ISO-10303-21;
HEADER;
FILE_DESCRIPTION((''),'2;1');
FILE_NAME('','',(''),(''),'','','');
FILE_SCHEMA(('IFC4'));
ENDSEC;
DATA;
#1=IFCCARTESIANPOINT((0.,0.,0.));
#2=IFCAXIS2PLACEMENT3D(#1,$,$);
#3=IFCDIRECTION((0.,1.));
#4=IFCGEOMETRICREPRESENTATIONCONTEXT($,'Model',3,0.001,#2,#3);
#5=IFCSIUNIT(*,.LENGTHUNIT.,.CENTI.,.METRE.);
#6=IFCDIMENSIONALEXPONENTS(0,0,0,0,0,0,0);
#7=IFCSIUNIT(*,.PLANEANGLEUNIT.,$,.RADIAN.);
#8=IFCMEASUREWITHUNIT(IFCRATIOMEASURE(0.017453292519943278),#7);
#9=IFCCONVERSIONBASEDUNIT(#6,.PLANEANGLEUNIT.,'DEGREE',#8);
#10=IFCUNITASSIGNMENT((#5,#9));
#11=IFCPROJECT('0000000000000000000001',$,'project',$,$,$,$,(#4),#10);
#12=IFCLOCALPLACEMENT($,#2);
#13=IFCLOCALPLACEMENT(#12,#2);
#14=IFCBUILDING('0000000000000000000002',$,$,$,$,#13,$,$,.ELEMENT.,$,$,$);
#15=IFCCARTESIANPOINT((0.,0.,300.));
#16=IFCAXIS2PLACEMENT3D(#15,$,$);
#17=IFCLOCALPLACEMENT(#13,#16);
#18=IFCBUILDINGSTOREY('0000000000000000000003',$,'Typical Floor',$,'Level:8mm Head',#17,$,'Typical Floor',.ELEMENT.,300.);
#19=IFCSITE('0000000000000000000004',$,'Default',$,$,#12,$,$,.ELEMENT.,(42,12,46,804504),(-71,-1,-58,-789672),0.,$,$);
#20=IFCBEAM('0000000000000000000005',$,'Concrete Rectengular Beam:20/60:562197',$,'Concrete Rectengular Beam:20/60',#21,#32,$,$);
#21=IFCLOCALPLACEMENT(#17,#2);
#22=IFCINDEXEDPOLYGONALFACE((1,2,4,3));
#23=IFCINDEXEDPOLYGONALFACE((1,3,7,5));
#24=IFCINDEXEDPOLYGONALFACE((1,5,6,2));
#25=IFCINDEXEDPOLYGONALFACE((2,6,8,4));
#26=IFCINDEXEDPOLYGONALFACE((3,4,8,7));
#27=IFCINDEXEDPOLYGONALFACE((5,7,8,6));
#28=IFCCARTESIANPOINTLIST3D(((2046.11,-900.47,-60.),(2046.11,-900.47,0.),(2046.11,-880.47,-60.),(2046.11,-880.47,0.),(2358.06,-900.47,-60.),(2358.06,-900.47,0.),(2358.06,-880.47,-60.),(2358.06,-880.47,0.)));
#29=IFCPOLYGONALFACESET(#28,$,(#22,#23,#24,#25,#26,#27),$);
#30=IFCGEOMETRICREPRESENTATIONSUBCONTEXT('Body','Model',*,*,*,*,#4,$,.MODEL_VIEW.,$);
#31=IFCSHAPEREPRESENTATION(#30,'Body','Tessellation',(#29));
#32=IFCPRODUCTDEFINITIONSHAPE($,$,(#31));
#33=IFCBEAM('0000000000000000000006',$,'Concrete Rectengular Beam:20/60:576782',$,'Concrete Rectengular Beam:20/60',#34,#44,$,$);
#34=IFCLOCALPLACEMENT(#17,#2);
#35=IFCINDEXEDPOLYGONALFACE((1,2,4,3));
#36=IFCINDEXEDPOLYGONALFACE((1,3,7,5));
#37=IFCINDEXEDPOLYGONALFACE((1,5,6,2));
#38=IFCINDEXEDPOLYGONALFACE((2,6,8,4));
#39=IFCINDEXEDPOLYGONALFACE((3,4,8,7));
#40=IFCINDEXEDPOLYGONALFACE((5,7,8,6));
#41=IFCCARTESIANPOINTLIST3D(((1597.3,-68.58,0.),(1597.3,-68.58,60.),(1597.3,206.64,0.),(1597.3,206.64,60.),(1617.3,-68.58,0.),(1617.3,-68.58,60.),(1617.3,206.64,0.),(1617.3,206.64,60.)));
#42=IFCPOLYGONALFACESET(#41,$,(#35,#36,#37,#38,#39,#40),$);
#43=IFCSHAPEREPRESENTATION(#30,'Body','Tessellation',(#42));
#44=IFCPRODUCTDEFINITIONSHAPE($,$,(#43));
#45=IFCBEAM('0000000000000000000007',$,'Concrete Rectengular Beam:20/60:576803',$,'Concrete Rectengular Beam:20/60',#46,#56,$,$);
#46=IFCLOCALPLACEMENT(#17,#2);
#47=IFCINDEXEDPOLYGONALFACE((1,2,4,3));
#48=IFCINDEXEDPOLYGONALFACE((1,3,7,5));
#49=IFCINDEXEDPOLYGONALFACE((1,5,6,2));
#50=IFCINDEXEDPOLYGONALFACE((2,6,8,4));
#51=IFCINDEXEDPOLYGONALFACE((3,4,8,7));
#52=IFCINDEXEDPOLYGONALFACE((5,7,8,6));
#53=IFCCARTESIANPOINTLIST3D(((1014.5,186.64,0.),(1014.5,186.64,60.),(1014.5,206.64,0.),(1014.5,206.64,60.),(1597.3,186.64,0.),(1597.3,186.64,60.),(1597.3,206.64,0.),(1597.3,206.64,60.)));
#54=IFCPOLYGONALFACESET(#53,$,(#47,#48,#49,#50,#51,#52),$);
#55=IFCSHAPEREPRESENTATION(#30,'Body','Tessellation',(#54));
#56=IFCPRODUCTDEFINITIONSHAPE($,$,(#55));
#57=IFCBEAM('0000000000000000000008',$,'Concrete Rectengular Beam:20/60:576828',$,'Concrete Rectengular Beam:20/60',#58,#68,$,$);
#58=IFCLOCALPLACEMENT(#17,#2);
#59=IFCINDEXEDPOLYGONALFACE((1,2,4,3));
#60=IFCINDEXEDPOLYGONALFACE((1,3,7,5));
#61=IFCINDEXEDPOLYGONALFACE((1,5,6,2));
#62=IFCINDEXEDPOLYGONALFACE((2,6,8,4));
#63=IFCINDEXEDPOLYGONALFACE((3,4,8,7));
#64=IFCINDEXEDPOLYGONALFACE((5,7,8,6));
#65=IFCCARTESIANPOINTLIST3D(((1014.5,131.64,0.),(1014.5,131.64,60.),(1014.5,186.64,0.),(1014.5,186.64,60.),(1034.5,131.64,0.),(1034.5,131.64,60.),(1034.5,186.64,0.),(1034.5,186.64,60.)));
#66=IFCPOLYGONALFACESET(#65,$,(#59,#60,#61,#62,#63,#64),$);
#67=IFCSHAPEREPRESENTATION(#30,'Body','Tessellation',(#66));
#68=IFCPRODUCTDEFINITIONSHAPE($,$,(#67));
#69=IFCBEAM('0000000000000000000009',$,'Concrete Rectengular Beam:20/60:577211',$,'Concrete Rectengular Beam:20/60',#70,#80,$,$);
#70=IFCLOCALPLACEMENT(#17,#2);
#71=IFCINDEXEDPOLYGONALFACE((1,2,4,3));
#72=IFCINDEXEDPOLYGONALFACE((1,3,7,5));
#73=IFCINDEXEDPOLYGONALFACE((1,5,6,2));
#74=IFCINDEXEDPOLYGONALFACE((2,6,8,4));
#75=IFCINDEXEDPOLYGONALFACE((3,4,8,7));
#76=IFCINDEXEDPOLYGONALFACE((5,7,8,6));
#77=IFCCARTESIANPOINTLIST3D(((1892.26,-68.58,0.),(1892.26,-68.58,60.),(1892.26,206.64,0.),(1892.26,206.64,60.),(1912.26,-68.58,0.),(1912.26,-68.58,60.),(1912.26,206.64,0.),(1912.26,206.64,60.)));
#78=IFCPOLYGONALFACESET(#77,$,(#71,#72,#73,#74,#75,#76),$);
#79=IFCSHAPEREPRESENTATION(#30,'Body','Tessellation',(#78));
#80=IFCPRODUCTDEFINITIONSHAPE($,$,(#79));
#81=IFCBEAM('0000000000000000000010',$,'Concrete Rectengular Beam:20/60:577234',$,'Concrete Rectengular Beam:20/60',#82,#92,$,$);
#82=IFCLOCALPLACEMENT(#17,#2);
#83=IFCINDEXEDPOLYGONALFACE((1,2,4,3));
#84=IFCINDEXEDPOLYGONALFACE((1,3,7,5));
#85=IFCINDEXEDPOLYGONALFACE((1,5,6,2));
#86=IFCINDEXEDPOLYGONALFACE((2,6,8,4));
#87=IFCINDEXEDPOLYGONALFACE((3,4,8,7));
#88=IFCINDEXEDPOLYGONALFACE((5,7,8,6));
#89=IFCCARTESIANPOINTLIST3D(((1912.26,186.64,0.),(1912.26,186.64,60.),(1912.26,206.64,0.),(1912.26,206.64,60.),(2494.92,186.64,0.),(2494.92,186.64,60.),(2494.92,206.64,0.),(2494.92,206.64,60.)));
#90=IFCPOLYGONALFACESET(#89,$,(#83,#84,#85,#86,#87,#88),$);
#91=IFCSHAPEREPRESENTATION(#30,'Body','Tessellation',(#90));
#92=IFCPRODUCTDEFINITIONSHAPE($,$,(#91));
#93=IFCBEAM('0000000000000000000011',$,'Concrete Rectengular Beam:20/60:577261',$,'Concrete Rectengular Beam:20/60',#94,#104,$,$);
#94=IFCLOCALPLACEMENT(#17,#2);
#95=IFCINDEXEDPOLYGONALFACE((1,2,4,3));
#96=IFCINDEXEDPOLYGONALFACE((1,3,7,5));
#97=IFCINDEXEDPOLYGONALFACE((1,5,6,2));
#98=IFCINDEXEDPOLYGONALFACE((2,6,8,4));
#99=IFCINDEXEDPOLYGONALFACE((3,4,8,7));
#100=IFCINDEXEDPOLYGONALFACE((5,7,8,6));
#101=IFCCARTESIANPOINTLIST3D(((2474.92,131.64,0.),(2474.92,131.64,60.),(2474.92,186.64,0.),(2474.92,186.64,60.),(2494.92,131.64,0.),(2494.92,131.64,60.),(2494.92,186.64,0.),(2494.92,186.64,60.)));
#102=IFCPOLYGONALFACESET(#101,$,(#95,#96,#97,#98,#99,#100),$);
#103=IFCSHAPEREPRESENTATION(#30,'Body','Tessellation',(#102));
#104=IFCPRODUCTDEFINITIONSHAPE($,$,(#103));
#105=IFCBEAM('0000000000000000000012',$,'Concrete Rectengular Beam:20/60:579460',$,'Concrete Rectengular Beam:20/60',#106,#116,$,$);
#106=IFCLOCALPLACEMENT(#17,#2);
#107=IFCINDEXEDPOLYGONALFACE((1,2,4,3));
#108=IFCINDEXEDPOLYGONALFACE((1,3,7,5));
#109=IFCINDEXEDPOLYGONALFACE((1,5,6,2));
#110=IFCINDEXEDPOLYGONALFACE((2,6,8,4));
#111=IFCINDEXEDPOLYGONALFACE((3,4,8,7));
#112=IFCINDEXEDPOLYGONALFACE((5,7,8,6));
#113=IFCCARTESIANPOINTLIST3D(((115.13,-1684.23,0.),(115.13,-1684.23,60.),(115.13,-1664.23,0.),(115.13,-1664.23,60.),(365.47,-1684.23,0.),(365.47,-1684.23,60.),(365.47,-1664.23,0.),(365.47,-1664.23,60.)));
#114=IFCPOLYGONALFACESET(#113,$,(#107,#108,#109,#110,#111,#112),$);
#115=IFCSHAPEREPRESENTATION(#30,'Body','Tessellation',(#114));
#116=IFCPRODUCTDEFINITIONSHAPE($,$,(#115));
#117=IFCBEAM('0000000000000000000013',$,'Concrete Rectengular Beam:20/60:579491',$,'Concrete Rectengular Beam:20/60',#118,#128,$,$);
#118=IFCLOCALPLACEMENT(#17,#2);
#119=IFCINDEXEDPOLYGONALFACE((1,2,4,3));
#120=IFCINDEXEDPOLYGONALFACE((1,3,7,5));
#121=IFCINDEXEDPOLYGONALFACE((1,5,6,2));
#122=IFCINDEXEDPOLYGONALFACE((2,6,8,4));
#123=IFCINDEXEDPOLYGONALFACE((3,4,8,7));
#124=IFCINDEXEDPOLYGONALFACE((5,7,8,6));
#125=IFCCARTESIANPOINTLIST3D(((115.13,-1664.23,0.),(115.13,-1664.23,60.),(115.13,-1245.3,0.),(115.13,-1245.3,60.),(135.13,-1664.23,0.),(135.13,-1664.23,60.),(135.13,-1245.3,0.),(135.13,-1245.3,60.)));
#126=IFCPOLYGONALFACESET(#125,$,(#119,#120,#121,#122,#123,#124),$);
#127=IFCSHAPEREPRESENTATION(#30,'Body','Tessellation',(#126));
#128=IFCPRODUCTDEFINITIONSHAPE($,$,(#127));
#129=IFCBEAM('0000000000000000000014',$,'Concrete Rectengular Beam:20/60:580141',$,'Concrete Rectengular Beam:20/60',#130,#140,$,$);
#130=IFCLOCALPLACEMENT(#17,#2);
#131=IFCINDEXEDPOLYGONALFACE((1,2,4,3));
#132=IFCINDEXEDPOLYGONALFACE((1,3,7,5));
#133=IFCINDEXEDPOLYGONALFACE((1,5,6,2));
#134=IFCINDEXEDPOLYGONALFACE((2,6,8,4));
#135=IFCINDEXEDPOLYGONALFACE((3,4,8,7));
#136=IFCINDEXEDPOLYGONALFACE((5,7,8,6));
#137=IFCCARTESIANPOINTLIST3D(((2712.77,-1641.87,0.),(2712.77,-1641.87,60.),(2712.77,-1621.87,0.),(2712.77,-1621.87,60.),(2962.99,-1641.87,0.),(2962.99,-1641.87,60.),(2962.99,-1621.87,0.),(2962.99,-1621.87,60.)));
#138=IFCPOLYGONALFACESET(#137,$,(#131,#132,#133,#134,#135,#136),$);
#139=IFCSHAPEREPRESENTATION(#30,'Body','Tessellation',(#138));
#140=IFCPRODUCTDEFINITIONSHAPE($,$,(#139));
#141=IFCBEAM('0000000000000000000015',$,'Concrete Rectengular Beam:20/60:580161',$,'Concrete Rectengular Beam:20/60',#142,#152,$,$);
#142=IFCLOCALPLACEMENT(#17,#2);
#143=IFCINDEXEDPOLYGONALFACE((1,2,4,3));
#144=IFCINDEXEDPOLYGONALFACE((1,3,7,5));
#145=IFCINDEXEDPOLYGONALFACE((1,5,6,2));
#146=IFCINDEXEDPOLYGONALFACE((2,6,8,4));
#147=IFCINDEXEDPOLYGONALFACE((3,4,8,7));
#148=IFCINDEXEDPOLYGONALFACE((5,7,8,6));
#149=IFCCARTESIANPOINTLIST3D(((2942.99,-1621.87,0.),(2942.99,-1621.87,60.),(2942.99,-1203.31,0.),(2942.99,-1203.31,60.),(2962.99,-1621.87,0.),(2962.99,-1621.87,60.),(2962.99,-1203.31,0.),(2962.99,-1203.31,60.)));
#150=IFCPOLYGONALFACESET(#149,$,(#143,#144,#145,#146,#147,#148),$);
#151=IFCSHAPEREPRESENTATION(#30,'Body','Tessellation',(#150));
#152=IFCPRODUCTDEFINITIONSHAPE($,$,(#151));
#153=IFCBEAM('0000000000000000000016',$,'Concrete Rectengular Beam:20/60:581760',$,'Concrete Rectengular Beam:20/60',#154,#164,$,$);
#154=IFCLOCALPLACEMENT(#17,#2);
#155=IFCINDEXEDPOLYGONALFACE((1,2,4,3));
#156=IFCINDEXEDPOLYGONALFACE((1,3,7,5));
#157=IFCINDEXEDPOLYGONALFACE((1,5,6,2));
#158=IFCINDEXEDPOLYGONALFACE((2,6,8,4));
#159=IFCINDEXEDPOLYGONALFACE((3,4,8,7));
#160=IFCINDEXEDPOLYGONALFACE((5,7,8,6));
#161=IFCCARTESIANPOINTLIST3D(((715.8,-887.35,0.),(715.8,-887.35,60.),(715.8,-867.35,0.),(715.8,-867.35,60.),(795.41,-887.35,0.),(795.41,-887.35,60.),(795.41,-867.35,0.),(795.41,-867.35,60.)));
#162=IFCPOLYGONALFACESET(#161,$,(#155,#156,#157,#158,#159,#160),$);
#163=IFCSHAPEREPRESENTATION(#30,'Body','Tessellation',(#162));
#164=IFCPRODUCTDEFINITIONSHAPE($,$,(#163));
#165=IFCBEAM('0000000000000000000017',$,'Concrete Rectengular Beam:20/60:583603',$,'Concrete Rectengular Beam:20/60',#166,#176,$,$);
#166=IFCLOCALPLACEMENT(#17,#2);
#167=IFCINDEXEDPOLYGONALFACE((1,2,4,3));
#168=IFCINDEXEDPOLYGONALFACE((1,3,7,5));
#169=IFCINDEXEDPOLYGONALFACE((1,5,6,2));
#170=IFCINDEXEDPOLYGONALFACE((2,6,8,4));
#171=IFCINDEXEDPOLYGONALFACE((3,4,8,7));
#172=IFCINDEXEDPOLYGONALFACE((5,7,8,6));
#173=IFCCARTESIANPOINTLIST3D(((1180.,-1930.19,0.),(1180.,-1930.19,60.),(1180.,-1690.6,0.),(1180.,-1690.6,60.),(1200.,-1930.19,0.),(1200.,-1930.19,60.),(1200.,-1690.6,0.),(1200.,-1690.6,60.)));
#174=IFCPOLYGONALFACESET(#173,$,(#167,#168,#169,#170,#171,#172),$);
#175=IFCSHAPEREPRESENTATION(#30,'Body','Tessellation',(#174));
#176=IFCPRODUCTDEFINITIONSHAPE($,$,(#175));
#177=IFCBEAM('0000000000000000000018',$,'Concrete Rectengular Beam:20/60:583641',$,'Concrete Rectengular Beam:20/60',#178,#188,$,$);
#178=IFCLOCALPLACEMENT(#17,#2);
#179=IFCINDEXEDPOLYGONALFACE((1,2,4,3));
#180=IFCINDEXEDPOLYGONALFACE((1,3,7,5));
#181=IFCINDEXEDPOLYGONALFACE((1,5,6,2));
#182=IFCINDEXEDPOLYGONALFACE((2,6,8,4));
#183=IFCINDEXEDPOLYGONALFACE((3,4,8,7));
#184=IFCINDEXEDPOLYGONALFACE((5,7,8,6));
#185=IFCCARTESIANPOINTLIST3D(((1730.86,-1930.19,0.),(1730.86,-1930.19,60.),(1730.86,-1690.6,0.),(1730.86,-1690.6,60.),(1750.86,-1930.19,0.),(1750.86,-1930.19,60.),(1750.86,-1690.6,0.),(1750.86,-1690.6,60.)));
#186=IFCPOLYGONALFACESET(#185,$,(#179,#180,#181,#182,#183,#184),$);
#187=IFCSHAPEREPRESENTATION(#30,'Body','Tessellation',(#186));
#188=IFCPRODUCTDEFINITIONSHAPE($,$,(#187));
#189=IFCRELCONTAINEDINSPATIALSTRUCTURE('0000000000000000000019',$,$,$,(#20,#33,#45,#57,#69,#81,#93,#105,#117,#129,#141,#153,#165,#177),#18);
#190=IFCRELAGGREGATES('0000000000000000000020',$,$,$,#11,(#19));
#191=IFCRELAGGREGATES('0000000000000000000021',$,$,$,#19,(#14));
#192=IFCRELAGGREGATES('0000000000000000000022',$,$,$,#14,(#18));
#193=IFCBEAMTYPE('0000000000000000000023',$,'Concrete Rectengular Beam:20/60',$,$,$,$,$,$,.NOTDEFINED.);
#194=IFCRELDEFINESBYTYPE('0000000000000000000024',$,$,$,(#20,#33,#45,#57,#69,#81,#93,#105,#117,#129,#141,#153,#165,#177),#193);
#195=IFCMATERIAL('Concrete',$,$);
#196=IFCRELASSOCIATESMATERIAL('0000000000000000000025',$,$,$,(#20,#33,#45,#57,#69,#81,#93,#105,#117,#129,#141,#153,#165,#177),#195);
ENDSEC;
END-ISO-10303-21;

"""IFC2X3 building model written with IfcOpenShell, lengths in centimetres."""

from ifc_helpers import new_model, entity, si_unit, converted_unit, direction, frame, frame_2d, origin, origin_2d_with_axis, place, context, subcontext, project, spatial, rectangle, extrude, material, type_object, element, save


model = new_model("IFC2X3")

# Units and contexts
model_context = context("Model", 3, precision=0.001, world=origin(), true_north=direction((0.0, 1.0)))
body_context = subcontext(model_context, "Body", "Model", "MODEL_VIEW")
ifc_project = project(units=[si_unit("LENGTHUNIT", "METRE", prefix="CENTI"), converted_unit("PLANEANGLEUNIT", "DEGREE", entity("IfcRatioMeasure", 0.017453292519943278), si_unit("PLANEANGLEUNIT", "RADIAN"), dimensions=[0, 0, 0, 0, 0, 0, 0])], contexts=[model_context])

# Site, building, storey
site_placement = place(None, origin())
site = spatial("IfcSite", under=ifc_project, at=site_placement, Name="Default", CompositionType="ELEMENT", RefLatitude=(42, 12, 46, 804504), RefLongitude=(-71, -1, -58, -789672), RefElevation=0.0)
building_placement = place(site_placement, origin())
building = spatial("IfcBuilding", under=site, at=building_placement, CompositionType="ELEMENT")
storey_placement = place(building_placement, frame((0.0, 0.0, 300.0)))
storey = spatial("IfcBuildingStorey", under=building, at=storey_placement, Name="Typical Floor", ObjectType="Level:8mm Head", LongName="Typical Floor", CompositionType="ELEMENT", Elevation=300.0)

# Beams
ifc_material = material(Name="Concrete")
beam_type_1 = type_object("IfcBeamType", Name="Concrete Rectengular Beam:20/60", PredefinedType="NOTDEFINED")
beam_1_placement = place(storey_placement, frame((2368.06, -890.47, 0.0), z_axis=(0.0, 0.0, 1.0), x_axis=(-1.0, 0.0, 0.0)))
element("IfcBeam", 1, at=beam_1_placement, inside=storey, type_object=beam_type_1, material=ifc_material, Name="Concrete Rectengular Beam:20/60:562197", ObjectType="Concrete Rectengular Beam:20/60", context=body_context, shape_type="SweptSolid", body=[
    extrude(rectangle(XDim=60.0, YDim=20.0, at=frame_2d((0.0, 0.0), x_axis=(1.0, 0.0))), frame((10.0, 0.0, -30.0), z_axis=(1.0, 0.0, 0.0), x_axis=(0.0, 0.0, -1.0)), (0.0, 0.0, 1.0), 311.95),
])
beam_2_placement = place(storey_placement, frame((1607.3, -68.58, 0.0), z_axis=(0.0, 0.0, 1.0), x_axis=(0.0, 1.0, 0.0)))
element("IfcBeam", 2, at=beam_2_placement, inside=storey, type_object=beam_type_1, material=ifc_material, Name="Concrete Rectengular Beam:20/60:576782", ObjectType="Concrete Rectengular Beam:20/60", context=body_context, shape_type="SweptSolid", body=[
    extrude(rectangle(XDim=60.0, YDim=20.0, at=frame_2d((0.0, 0.0), x_axis=(1.0, 0.0))), frame((0.0, 0.0, 30.0), z_axis=(1.0, 0.0, 0.0), x_axis=(0.0, 0.0, -1.0)), (0.0, 0.0, 1.0), 275.22),
])
beam_3_placement = place(storey_placement, frame((1607.3, 196.64, 0.0), z_axis=(0.0, 0.0, 1.0), x_axis=(-1.0, 0.0, 0.0)))
element("IfcBeam", 3, at=beam_3_placement, inside=storey, type_object=beam_type_1, material=ifc_material, Name="Concrete Rectengular Beam:20/60:576803", ObjectType="Concrete Rectengular Beam:20/60", context=body_context, shape_type="SweptSolid", body=[
    extrude(rectangle(XDim=60.0, YDim=20.0, at=frame_2d((0.0, 0.0), x_axis=(1.0, 0.0))), frame((10.0, 0.0, 30.0), z_axis=(1.0, 0.0, 0.0), x_axis=(0.0, 0.0, -1.0)), (0.0, 0.0, 1.0), 582.8),
])
beam_4_placement = place(storey_placement, frame((1024.5, 196.64, 0.0), z_axis=(0.0, 0.0, 1.0), x_axis=(0.0, -1.0, 0.0)))
element("IfcBeam", 4, at=beam_4_placement, inside=storey, type_object=beam_type_1, material=ifc_material, Name="Concrete Rectengular Beam:20/60:576828", ObjectType="Concrete Rectengular Beam:20/60", context=body_context, shape_type="SweptSolid", body=[
    extrude(rectangle(XDim=60.0, YDim=20.0, at=frame_2d((0.0, 0.0), x_axis=(1.0, 0.0))), frame((10.0, 0.0, 30.0), z_axis=(1.0, 0.0, 0.0), x_axis=(0.0, 0.0, -1.0)), (0.0, 0.0, 1.0), 55.0),
])
beam_5_placement = place(storey_placement, frame((1902.26, -68.58, 0.0), z_axis=(0.0, 0.0, 1.0), x_axis=(0.0, 1.0, 0.0)))
element("IfcBeam", 5, at=beam_5_placement, inside=storey, type_object=beam_type_1, material=ifc_material, Name="Concrete Rectengular Beam:20/60:577211", ObjectType="Concrete Rectengular Beam:20/60", context=body_context, shape_type="SweptSolid", body=[
    extrude(rectangle(XDim=60.0, YDim=20.0, at=frame_2d((0.0, 0.0), x_axis=(1.0, 0.0))), frame((0.0, 0.0, 30.0), z_axis=(1.0, 0.0, 0.0), x_axis=(0.0, 0.0, -1.0)), (0.0, 0.0, 1.0), 275.22),
])
beam_6_placement = place(storey_placement, frame((1902.26, 196.64, 0.0)))
element("IfcBeam", 6, at=beam_6_placement, inside=storey, type_object=beam_type_1, material=ifc_material, Name="Concrete Rectengular Beam:20/60:577234", ObjectType="Concrete Rectengular Beam:20/60", context=body_context, shape_type="SweptSolid", body=[
    extrude(rectangle(XDim=60.0, YDim=20.0, at=frame_2d((0.0, 0.0), x_axis=(1.0, 0.0))), frame((10.0, 0.0, 30.0), z_axis=(1.0, 0.0, 0.0), x_axis=(0.0, 0.0, -1.0)), (0.0, 0.0, 1.0), 582.66),
])
beam_7_placement = place(storey_placement, frame((2484.92, 196.64, 0.0), z_axis=(0.0, 0.0, 1.0), x_axis=(0.0, -1.0, 0.0)))
element("IfcBeam", 7, at=beam_7_placement, inside=storey, type_object=beam_type_1, material=ifc_material, Name="Concrete Rectengular Beam:20/60:577261", ObjectType="Concrete Rectengular Beam:20/60", context=body_context, shape_type="SweptSolid", body=[
    extrude(rectangle(XDim=60.0, YDim=20.0, at=origin_2d_with_axis()), frame((10.0, 0.0, 30.0), z_axis=(1.0, 0.0, 0.0), x_axis=(0.0, 0.0, -1.0)), (0.0, 0.0, 1.0), 55.0),
])
beam_8_placement = place(storey_placement, frame((365.47, -1674.23, 0.0), z_axis=(0.0, 0.0, 1.0), x_axis=(-1.0, 0.0, 0.0)))
element("IfcBeam", 8, at=beam_8_placement, inside=storey, type_object=beam_type_1, material=ifc_material, Name="Concrete Rectengular Beam:20/60:579460", ObjectType="Concrete Rectengular Beam:20/60", context=body_context, shape_type="SweptSolid", body=[
    extrude(rectangle(XDim=60.0, YDim=20.0, at=frame_2d((0.0, 0.0), x_axis=(1.0, 0.0))), frame((0.0, 0.0, 30.0), z_axis=(1.0, 0.0, 0.0), x_axis=(0.0, 0.0, -1.0)), (0.0, 0.0, 1.0), 250.34),
])
beam_9_placement = place(storey_placement, frame((125.13, -1674.23, 0.0), z_axis=(0.0, 0.0, 1.0), x_axis=(0.0, 1.0, 0.0)))
element("IfcBeam", 9, at=beam_9_placement, inside=storey, type_object=beam_type_1, material=ifc_material, Name="Concrete Rectengular Beam:20/60:579491", ObjectType="Concrete Rectengular Beam:20/60", context=body_context, shape_type="SweptSolid", body=[
    extrude(rectangle(XDim=60.0, YDim=20.0, at=frame_2d((0.0, 0.0), x_axis=(1.0, 0.0))), frame((10.0, 0.0, 30.0), z_axis=(1.0, 0.0, 0.0), x_axis=(0.0, 0.0, -1.0)), (0.0, 0.0, 1.0), 418.93),
])
beam_10_placement = place(storey_placement, frame((2712.77, -1631.87, 0.0)))
element("IfcBeam", 10, at=beam_10_placement, inside=storey, type_object=beam_type_1, material=ifc_material, Name="Concrete Rectengular Beam:20/60:580141", ObjectType="Concrete Rectengular Beam:20/60", context=body_context, shape_type="SweptSolid", body=[
    extrude(rectangle(XDim=60.0, YDim=20.0, at=frame_2d((0.0, 0.0), x_axis=(1.0, 0.0))), frame((0.0, 0.0, 30.0), z_axis=(1.0, 0.0, 0.0), x_axis=(0.0, 0.0, -1.0)), (0.0, 0.0, 1.0), 250.23),
])
beam_11_placement = place(storey_placement, frame((2952.99, -1631.87, 0.0), z_axis=(0.0, 0.0, 1.0), x_axis=(0.0, 1.0, 0.0)))
element("IfcBeam", 11, at=beam_11_placement, inside=storey, type_object=beam_type_1, material=ifc_material, Name="Concrete Rectengular Beam:20/60:580161", ObjectType="Concrete Rectengular Beam:20/60", context=body_context, shape_type="SweptSolid", body=[
    extrude(rectangle(XDim=60.0, YDim=20.0, at=frame_2d((0.0, 0.0), x_axis=(1.0, 0.0))), frame((10.0, 0.0, 30.0), z_axis=(1.0, 0.0, 0.0), x_axis=(0.0, 0.0, -1.0)), (0.0, 0.0, 1.0), 418.56),
])
beam_12_placement = place(storey_placement, frame((715.8, -877.35, 0.0)))
element("IfcBeam", 12, at=beam_12_placement, inside=storey, type_object=beam_type_1, material=ifc_material, Name="Concrete Rectengular Beam:20/60:581760", ObjectType="Concrete Rectengular Beam:20/60", context=body_context, shape_type="SweptSolid", body=[
    extrude(rectangle(XDim=60.0, YDim=20.0, at=frame_2d((0.0, 0.0), x_axis=(1.0, 0.0))), frame((0.0, 0.0, 30.0), z_axis=(1.0, 0.0, 0.0), x_axis=(0.0, 0.0, -1.0)), (0.0, 0.0, 1.0), 79.61),
])
beam_13_placement = place(storey_placement, frame((1190.0, -1930.19, 0.0), z_axis=(0.0, 0.0, 1.0), x_axis=(0.0, 1.0, 0.0)))
element("IfcBeam", 13, at=beam_13_placement, inside=storey, type_object=beam_type_1, material=ifc_material, Name="Concrete Rectengular Beam:20/60:583603", ObjectType="Concrete Rectengular Beam:20/60", context=body_context, shape_type="SweptSolid", body=[
    extrude(rectangle(XDim=60.0, YDim=20.0, at=origin_2d_with_axis()), frame((0.0, 0.0, 30.0), z_axis=(1.0, 0.0, 0.0), x_axis=(0.0, 0.0, -1.0)), (0.0, 0.0, 1.0), 239.59),
])
beam_14_placement = place(storey_placement, frame((1740.86, -1930.19, 0.0), z_axis=(0.0, 0.0, 1.0), x_axis=(0.0, 1.0, 0.0)))
element("IfcBeam", 14, at=beam_14_placement, inside=storey, type_object=beam_type_1, material=ifc_material, Name="Concrete Rectengular Beam:20/60:583641", ObjectType="Concrete Rectengular Beam:20/60", context=body_context, shape_type="SweptSolid", body=[
    extrude(rectangle(XDim=60.0, YDim=20.0, at=frame_2d((0.0, 0.0), x_axis=(1.0, 0.0))), frame((0.0, 0.0, 30.0), z_axis=(1.0, 0.0, 0.0), x_axis=(0.0, 0.0, -1.0)), (0.0, 0.0, 1.0), 239.59),
])

save(model, "model.ifc")
